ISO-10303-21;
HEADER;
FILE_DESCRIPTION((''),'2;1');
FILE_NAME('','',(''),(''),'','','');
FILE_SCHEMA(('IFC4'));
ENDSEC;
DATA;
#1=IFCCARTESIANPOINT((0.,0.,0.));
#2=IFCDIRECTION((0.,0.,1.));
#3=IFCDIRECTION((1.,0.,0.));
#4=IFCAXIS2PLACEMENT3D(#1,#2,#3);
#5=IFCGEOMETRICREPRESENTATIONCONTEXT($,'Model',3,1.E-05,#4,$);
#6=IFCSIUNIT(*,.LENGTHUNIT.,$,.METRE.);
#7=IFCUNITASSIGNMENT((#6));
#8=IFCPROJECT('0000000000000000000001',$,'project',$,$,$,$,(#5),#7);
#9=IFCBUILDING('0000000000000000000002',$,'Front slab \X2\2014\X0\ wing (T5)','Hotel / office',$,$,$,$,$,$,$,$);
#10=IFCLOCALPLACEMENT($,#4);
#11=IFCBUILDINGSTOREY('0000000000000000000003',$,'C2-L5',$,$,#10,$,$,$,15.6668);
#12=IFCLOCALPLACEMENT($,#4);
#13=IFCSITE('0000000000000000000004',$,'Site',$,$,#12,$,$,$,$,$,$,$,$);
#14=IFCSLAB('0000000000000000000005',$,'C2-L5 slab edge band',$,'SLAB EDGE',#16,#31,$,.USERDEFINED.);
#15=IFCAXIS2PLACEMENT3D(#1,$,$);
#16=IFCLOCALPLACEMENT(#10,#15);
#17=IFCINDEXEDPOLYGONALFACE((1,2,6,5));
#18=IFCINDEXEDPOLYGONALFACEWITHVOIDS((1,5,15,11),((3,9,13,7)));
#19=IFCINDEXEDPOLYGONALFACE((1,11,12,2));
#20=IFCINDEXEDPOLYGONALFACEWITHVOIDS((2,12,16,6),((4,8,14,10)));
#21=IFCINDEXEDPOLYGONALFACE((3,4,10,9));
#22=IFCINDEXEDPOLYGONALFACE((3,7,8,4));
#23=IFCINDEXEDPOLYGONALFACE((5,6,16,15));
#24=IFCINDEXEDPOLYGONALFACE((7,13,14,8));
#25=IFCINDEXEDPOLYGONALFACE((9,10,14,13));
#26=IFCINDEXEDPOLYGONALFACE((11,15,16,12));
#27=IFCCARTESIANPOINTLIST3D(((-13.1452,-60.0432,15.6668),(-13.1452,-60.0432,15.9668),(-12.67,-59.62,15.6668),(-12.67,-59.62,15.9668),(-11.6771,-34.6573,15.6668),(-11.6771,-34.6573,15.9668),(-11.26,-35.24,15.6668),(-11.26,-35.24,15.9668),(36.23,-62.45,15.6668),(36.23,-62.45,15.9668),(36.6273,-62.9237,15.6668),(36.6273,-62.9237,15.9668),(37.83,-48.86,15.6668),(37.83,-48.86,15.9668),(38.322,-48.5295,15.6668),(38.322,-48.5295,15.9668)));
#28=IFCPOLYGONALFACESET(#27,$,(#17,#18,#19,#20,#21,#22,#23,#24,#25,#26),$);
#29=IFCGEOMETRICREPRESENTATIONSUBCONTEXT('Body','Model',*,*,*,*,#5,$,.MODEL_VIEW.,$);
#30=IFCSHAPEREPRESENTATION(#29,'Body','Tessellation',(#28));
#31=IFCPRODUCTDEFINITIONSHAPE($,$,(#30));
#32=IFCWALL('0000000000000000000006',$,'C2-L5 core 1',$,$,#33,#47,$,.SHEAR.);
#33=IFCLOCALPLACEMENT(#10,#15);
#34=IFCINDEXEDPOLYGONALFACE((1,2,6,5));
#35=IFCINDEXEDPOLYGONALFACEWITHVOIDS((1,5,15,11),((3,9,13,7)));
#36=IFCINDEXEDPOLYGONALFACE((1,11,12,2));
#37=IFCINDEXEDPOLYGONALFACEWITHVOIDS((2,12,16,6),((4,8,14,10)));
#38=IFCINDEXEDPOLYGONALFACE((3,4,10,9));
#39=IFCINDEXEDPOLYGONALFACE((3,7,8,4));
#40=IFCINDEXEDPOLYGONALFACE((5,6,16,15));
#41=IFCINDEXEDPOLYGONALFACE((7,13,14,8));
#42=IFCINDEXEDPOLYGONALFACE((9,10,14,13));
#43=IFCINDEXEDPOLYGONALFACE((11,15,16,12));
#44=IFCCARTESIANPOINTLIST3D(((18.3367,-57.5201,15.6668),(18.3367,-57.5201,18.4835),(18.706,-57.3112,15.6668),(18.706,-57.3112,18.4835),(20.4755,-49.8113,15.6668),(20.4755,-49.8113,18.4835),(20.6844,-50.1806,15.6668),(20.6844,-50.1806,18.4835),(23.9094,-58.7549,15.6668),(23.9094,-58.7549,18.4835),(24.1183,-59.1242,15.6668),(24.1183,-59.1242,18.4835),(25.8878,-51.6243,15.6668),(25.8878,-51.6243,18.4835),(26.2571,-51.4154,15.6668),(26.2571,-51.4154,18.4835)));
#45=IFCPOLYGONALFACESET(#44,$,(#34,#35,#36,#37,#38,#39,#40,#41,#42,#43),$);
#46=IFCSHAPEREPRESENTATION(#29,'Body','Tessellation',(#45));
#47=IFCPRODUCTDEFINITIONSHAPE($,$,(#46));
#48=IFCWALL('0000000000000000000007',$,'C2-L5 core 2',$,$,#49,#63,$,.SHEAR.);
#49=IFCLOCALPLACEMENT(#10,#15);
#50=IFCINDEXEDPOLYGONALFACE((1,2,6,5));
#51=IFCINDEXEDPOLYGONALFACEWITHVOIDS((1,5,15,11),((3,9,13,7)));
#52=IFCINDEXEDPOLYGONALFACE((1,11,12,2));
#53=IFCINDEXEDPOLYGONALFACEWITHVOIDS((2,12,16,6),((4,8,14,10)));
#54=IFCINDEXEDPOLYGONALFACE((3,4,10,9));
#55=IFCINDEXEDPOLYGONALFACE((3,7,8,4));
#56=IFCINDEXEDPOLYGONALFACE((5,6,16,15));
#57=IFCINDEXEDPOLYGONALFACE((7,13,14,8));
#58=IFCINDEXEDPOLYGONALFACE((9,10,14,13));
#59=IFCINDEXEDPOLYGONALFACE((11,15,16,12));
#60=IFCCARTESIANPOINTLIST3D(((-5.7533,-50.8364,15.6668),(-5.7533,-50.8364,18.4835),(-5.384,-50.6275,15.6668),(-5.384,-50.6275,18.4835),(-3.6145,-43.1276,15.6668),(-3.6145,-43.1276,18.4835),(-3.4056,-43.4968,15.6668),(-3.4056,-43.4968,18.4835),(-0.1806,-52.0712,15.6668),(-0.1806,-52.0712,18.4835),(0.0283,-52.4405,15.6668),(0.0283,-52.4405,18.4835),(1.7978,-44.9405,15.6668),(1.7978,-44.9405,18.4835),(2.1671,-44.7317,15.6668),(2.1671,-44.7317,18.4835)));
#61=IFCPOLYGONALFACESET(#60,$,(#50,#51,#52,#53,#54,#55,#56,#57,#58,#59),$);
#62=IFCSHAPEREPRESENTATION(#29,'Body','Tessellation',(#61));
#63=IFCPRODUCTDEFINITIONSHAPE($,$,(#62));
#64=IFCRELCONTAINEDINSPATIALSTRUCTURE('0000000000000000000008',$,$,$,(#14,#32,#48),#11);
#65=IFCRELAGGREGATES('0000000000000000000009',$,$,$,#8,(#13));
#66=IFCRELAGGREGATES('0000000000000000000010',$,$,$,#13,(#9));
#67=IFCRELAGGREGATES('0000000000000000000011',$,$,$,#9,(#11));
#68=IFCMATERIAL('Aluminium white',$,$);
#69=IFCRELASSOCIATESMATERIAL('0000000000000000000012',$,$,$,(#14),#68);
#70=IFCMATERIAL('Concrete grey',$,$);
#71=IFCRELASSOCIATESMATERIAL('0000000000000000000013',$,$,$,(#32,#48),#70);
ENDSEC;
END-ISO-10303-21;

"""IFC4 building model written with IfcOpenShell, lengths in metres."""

from ifc_helpers import new_model, si_unit, frame, origin_with_axes, place, context, subcontext, project, spatial, polyline, outline, extrude, material, element, save


model = new_model("IFC4")

# Units and contexts
model_context = context("Model", 3, precision=1e-05, world=origin_with_axes())
body_context = subcontext(model_context, "Body", "Model", "MODEL_VIEW")
ifc_project = project(units=[si_unit("LENGTHUNIT", "METRE")], contexts=[model_context])

# Site, building, storey
site_placement = place(None, origin_with_axes())
site = spatial("IfcSite", under=ifc_project, at=site_placement, Name="Site")
building = spatial("IfcBuilding", under=site, Name="Front slab — wing (T5)", Description="Hotel / office")
storey_placement = place(None, origin_with_axes())
storey = spatial("IfcBuildingStorey", under=building, at=storey_placement, Name="C2-L5", Elevation=15.6668)

# Shared definitions
ifc_material_1 = material(Name="Aluminium white")

# Slab
slab_placement = place(storey_placement, origin_with_axes())
element("IfcSlab", 1, at=slab_placement, inside=storey, material=ifc_material_1, Name="C2-L5 slab edge band", ObjectType="SLAB EDGE", PredefinedType="USERDEFINED", context=body_context, shape_type="SweptSolid", body=[
    extrude(outline(polyline([(-11.6771, -34.6573), (-13.1452, -60.0432), (36.6273, -62.9237), (38.322, -48.5295), (-11.6771, -34.6573)]), holes=[polyline([(-11.26, -35.24), (-12.67, -59.62), (36.23, -62.45), (37.83, -48.86), (-11.26, -35.24)])]), frame((0.0, 0.0, 15.6668), z_axis=(0.0, 0.0, 1.0), x_axis=(1.0, 0.0, 0.0)), (0.0, 0.0, 1.0), 0.3),
])

# Walls
ifc_material_2 = material(Name="Concrete grey")
wall_1_placement = place(storey_placement, origin_with_axes())
element("IfcWall", 2, at=wall_1_placement, inside=storey, material=ifc_material_2, Name="C2-L5 core 1", PredefinedType="SHEAR", context=body_context, shape_type="SweptSolid", body=[
    extrude(outline(polyline([(26.2571, -51.4154), (20.4755, -49.8113), (18.3367, -57.5201), (24.1183, -59.1242), (26.2571, -51.4154)]), holes=[polyline([(25.8878, -51.6243), (20.6844, -50.1806), (18.706, -57.3112), (23.9094, -58.7549), (25.8878, -51.6243)])]), frame((0.0, 0.0, 15.6668), z_axis=(0.0, 0.0, 1.0), x_axis=(1.0, 0.0, 0.0)), (0.0, 0.0, 1.0), 2.8167),
])
wall_2_placement = place(storey_placement, origin_with_axes())
element("IfcWall", 3, at=wall_2_placement, inside=storey, material=ifc_material_2, Name="C2-L5 core 2", PredefinedType="SHEAR", context=body_context, shape_type="SweptSolid", body=[
    extrude(outline(polyline([(2.1671, -44.7317), (-3.6145, -43.1276), (-5.7533, -50.8364), (0.0283, -52.4405), (2.1671, -44.7317)]), holes=[polyline([(1.7978, -44.9405), (-3.4056, -43.4968), (-5.384, -50.6275), (-0.1806, -52.0712), (1.7978, -44.9405)])]), frame((0.0, 0.0, 15.6668), z_axis=(0.0, 0.0, 1.0), x_axis=(1.0, 0.0, 0.0)), (0.0, 0.0, 1.0), 2.8167),
])

save(model, "model.ifc")
